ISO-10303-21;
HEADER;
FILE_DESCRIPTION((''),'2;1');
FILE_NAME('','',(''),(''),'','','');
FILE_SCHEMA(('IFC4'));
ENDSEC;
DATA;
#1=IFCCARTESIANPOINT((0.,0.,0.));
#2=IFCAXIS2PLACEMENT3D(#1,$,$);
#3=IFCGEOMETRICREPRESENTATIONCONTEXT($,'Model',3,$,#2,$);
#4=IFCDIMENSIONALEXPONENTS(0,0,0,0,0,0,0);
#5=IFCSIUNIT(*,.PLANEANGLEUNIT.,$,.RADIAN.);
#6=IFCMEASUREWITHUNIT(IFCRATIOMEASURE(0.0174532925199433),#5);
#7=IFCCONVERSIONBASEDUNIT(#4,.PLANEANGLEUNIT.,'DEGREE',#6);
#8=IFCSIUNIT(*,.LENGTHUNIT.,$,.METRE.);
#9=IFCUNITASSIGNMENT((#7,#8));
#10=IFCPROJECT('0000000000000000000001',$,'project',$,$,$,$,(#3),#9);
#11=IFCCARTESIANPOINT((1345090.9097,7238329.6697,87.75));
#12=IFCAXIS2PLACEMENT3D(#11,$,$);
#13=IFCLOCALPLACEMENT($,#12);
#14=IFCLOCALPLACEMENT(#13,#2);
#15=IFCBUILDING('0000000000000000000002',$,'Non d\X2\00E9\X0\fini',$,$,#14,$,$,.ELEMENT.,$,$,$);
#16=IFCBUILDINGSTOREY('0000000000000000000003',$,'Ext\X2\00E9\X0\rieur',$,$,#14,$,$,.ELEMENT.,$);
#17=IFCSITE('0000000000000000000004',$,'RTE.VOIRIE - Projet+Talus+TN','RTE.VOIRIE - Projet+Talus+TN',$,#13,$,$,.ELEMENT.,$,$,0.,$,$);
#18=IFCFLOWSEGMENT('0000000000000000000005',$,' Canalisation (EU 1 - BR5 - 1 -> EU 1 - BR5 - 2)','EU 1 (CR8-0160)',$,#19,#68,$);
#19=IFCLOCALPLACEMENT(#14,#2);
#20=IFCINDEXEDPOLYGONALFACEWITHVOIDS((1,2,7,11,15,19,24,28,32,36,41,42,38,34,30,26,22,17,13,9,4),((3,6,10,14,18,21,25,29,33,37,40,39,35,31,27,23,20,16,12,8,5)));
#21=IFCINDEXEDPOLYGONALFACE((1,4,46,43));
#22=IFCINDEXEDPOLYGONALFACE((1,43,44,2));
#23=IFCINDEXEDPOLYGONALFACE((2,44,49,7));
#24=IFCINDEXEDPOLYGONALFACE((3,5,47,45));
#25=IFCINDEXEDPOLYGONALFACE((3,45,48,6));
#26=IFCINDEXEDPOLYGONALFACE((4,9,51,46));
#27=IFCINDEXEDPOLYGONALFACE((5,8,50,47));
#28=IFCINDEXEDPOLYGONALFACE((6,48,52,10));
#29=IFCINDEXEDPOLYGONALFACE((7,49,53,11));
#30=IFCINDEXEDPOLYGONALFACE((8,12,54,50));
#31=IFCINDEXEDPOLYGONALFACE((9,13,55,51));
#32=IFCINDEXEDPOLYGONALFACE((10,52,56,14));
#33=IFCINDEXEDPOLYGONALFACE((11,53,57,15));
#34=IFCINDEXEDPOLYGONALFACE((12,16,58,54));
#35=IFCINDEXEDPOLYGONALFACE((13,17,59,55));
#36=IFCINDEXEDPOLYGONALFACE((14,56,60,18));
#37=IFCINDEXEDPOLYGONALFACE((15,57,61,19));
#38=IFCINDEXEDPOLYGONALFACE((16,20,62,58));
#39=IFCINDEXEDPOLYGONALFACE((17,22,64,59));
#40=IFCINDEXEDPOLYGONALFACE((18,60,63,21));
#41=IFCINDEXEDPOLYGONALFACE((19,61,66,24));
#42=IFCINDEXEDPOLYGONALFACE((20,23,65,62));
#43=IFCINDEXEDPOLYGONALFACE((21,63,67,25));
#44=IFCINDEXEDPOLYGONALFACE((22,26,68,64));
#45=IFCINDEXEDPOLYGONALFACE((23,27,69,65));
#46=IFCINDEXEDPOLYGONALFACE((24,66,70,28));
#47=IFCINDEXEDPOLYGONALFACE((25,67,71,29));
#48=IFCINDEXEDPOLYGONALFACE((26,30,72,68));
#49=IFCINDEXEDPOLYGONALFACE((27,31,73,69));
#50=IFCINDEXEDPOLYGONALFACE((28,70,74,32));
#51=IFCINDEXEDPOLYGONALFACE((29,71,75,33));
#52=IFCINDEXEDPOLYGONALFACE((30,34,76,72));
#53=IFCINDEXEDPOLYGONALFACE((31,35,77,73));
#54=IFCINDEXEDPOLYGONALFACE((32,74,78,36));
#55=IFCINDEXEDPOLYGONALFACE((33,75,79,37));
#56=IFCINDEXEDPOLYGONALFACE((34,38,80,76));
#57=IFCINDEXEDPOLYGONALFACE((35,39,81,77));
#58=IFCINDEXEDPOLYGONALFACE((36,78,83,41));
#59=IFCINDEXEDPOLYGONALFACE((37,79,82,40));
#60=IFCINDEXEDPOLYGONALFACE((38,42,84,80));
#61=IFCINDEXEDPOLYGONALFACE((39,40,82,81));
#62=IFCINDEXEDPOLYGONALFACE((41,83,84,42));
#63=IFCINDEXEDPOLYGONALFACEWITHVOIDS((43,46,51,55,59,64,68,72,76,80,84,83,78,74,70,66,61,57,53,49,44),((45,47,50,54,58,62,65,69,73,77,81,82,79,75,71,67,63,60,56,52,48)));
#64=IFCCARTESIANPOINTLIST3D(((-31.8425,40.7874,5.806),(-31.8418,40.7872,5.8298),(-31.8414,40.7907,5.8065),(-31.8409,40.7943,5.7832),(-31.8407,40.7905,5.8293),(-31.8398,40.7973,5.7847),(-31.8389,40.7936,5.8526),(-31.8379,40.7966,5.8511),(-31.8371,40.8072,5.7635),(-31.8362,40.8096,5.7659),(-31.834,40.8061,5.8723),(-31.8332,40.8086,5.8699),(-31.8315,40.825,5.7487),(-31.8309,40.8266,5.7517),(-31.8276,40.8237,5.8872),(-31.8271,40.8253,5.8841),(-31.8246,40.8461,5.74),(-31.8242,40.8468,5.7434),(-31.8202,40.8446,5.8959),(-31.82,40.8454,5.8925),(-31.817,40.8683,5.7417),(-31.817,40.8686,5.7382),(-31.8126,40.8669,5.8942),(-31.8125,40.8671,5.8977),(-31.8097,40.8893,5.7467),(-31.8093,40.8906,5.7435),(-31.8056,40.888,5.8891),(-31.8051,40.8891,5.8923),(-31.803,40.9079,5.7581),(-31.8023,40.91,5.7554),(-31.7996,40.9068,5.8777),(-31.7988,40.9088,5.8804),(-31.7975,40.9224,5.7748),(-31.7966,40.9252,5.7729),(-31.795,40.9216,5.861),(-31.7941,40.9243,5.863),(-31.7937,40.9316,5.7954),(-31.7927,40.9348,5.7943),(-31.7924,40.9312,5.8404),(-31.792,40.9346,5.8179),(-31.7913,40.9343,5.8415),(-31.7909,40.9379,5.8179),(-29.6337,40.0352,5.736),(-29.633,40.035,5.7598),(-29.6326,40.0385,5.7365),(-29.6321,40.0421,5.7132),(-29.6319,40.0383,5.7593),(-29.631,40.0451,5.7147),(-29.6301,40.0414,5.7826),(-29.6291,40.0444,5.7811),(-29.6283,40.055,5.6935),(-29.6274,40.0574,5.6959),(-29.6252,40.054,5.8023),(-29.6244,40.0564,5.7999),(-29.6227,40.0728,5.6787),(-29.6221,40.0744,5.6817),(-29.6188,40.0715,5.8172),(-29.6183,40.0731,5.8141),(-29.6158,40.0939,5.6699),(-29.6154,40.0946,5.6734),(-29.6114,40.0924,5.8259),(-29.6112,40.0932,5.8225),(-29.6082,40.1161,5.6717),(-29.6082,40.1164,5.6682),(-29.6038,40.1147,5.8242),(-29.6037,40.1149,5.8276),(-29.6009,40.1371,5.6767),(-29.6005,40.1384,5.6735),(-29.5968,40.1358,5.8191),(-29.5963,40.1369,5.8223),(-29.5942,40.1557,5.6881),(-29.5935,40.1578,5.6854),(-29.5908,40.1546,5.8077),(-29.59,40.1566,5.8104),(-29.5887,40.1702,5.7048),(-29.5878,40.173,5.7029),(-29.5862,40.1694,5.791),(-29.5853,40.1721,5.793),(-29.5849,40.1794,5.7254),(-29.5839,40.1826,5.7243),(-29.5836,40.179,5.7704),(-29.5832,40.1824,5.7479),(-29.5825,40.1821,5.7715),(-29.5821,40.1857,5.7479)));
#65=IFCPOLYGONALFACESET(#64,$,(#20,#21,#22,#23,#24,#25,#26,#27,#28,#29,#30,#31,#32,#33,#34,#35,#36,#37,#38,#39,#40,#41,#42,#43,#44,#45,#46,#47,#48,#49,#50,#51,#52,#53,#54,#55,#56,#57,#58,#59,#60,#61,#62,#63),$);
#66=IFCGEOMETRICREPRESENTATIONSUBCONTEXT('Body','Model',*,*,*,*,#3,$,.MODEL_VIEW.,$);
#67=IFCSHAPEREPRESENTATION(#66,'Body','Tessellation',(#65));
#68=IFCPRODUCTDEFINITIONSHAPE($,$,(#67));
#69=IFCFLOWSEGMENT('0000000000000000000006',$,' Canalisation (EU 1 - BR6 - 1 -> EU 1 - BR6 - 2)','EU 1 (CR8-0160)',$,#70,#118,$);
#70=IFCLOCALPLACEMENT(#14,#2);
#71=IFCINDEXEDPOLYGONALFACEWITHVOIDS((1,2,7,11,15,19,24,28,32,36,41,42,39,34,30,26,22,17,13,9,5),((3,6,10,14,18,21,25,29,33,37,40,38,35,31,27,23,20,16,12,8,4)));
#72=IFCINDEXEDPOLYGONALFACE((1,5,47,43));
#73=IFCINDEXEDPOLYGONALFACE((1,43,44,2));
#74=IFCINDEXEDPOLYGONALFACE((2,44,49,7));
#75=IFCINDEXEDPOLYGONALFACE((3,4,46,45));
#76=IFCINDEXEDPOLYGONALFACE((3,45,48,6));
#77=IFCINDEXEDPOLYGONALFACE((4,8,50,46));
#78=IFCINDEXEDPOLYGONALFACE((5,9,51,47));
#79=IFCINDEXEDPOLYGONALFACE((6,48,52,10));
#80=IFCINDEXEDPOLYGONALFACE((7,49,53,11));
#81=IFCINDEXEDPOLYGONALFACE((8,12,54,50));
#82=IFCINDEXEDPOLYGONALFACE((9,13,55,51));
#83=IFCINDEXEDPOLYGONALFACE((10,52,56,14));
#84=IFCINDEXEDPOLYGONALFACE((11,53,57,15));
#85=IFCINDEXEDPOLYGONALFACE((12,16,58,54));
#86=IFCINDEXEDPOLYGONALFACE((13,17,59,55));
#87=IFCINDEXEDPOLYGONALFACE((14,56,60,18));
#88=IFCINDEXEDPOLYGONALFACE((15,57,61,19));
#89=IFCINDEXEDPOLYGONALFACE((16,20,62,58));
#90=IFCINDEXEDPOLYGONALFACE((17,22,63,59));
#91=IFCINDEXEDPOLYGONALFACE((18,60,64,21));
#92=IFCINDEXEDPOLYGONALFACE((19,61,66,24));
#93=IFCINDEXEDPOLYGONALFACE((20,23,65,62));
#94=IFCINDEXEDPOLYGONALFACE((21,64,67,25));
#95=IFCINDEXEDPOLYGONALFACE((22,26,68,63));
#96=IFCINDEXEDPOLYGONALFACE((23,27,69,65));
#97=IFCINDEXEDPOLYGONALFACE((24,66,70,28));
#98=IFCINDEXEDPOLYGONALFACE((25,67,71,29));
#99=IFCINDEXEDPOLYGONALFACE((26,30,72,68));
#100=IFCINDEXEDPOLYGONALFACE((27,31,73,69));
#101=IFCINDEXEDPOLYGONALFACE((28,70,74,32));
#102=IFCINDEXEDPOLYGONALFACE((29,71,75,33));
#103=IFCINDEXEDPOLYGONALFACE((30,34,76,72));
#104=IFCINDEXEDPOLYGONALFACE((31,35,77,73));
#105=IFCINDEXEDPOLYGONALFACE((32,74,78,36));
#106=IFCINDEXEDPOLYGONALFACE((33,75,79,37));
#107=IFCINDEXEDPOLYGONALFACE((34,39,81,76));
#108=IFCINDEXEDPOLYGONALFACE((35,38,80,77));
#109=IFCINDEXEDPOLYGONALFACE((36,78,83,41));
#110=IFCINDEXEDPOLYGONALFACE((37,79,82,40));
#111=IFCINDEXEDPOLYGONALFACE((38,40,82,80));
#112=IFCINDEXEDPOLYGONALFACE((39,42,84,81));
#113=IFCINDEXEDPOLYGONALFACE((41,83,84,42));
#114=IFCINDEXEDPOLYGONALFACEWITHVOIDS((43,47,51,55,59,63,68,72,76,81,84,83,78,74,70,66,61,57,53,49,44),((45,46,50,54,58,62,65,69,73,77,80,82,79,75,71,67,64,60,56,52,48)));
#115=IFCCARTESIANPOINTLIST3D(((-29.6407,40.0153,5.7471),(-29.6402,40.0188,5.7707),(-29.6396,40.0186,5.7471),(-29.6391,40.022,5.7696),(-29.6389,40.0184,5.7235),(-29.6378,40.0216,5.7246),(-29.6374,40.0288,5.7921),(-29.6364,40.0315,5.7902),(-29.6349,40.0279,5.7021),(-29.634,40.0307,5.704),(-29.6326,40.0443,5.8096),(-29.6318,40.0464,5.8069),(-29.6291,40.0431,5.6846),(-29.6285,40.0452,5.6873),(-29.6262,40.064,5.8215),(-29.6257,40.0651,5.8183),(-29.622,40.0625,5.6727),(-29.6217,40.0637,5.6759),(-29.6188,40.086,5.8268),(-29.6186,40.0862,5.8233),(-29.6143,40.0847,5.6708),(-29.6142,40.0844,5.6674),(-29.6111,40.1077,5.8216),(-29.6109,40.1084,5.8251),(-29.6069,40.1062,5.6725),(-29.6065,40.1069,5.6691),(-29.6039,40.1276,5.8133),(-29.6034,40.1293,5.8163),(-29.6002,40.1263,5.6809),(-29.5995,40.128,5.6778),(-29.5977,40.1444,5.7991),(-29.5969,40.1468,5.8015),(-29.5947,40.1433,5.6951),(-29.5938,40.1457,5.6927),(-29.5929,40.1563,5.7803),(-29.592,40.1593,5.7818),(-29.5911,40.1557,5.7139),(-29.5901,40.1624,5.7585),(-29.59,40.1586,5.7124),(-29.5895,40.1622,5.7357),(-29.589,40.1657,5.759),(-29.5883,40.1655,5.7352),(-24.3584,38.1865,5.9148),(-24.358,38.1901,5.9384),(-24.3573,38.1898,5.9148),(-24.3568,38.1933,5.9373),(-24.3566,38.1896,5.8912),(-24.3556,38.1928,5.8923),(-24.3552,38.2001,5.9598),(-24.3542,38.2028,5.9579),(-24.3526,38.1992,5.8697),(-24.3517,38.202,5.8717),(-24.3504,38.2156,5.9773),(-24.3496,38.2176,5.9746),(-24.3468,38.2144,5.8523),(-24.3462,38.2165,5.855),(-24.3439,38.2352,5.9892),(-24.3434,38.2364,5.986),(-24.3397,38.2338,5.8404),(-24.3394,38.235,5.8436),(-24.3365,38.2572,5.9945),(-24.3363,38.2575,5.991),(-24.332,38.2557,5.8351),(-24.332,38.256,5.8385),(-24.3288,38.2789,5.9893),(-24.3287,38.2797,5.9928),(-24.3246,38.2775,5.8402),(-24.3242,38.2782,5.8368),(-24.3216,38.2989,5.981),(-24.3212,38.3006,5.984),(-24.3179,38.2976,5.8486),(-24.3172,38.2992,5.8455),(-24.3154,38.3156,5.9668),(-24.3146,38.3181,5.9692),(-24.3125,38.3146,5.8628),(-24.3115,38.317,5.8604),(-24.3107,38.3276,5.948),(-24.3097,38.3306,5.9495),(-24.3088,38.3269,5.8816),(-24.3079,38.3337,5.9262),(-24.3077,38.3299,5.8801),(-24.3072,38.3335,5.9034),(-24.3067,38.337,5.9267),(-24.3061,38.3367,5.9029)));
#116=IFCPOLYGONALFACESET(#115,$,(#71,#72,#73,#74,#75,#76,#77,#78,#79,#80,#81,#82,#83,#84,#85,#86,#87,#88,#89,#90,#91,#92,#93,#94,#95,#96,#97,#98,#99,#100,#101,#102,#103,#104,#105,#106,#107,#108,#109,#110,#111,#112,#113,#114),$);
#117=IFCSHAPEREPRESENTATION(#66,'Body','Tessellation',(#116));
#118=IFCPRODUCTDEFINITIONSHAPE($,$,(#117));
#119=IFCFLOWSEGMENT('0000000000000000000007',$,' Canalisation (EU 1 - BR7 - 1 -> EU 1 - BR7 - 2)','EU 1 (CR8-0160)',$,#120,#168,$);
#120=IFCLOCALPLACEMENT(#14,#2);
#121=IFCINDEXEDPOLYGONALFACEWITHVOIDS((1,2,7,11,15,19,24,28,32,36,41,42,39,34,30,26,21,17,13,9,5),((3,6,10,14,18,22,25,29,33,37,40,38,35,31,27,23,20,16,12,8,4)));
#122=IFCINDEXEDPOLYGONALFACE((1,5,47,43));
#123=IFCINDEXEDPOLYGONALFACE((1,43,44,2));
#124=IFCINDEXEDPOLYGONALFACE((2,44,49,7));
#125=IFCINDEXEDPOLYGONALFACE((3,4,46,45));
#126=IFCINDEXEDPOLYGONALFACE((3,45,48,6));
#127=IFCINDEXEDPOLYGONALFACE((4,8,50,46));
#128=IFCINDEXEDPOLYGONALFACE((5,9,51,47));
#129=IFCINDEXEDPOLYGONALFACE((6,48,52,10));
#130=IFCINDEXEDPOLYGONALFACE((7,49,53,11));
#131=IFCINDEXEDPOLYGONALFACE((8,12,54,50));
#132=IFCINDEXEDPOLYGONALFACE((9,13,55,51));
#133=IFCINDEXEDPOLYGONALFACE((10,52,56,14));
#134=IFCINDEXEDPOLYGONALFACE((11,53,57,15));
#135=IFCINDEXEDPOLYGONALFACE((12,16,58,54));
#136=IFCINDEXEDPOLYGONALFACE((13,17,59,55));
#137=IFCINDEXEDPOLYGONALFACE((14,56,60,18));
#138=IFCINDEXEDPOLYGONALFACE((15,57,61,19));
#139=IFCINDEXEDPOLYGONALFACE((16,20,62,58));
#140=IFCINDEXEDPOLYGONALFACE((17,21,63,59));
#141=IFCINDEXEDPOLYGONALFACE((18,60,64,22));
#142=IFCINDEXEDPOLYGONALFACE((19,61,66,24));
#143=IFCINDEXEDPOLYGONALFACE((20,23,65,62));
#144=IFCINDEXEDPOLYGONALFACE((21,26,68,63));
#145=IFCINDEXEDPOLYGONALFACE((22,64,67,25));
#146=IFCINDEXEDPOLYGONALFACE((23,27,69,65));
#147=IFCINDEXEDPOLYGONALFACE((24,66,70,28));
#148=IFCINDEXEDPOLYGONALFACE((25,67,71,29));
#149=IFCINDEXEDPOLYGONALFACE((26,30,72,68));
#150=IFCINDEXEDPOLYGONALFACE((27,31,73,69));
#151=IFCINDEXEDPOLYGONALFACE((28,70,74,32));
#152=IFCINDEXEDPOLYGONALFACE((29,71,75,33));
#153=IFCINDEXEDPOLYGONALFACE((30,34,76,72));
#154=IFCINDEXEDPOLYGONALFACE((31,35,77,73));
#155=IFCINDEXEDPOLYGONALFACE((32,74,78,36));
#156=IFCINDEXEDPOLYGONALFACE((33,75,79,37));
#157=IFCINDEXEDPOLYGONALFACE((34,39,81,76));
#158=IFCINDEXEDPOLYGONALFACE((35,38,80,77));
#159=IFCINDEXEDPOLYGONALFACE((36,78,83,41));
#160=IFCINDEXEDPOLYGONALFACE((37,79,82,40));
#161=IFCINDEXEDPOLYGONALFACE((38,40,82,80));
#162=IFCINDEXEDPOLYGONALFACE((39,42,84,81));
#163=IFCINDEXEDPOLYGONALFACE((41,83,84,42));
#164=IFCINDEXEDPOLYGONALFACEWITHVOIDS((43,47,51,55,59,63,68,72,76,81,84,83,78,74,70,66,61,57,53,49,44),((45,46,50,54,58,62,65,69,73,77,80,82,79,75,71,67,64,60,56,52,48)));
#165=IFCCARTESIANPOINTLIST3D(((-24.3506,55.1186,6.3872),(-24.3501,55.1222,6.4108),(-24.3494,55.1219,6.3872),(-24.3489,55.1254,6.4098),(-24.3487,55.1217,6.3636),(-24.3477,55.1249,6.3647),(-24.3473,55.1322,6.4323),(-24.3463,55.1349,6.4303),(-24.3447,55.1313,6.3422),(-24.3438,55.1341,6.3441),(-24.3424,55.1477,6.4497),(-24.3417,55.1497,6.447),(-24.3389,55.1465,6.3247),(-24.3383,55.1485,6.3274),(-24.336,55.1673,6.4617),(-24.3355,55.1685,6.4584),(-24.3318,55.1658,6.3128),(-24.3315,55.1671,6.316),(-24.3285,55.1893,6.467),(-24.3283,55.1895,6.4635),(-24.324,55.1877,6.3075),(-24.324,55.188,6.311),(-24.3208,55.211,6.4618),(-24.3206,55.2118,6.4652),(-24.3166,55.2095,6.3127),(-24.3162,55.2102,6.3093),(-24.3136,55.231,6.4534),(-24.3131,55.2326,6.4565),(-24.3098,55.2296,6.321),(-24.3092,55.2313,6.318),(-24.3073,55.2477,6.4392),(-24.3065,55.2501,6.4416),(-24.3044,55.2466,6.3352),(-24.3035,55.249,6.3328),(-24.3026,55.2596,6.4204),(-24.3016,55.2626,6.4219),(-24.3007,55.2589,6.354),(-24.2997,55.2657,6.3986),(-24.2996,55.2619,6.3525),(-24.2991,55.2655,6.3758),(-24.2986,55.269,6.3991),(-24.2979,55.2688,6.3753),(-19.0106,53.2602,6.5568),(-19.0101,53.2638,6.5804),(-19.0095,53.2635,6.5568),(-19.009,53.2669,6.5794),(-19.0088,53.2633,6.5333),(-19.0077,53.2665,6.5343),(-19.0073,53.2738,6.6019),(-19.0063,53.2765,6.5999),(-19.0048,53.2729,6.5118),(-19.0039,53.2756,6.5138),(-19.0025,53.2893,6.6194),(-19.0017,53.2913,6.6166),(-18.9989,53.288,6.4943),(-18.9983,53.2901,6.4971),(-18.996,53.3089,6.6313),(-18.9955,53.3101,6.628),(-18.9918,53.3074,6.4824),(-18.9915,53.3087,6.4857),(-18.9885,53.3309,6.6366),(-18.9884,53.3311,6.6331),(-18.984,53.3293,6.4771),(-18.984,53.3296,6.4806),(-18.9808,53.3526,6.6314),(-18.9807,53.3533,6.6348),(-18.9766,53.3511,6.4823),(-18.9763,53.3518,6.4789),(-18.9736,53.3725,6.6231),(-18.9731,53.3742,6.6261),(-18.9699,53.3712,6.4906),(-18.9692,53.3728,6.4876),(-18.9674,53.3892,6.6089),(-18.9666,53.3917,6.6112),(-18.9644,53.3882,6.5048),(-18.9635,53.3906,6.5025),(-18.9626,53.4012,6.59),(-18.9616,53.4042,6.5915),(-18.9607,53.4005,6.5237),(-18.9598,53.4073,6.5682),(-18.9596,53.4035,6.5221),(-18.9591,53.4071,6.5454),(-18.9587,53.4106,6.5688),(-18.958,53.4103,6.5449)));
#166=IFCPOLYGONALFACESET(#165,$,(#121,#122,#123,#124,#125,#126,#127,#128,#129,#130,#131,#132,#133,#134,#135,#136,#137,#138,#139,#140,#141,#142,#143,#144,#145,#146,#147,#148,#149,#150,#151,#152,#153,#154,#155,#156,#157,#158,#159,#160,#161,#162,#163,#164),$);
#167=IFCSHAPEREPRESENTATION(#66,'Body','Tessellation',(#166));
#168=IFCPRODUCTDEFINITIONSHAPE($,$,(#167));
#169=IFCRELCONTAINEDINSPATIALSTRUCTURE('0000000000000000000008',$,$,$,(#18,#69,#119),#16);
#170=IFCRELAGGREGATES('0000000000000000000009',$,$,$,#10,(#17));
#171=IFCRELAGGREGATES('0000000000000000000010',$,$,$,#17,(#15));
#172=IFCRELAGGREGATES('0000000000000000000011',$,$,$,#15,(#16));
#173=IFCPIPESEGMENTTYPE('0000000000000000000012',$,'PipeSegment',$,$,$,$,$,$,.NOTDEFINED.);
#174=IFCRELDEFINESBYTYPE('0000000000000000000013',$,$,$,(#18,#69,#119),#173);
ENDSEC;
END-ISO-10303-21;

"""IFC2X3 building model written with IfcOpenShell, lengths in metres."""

from ifc_helpers import new_model, entity, si_unit, converted_unit, frame, origin, origin_2d_with_axis, place, context, subcontext, project, spatial, hollow_circle, extrude, type_object, element, save


model = new_model("IFC2X3")

# Units and contexts
model_context = context("Model", 3, world=origin())
body_context = subcontext(model_context, "Body", "Model", "MODEL_VIEW")
ifc_project = project(units=[converted_unit("PLANEANGLEUNIT", "DEGREE", entity("IfcRatioMeasure", 0.0174532925199433), si_unit("PLANEANGLEUNIT", "RADIAN"), dimensions=[0, 0, 0, 0, 0, 0, 0]), si_unit("LENGTHUNIT", "METRE")], contexts=[model_context])

# Site, building, storey
site_placement = place(None, frame((1345090.9097, 7238329.6697, 87.75)))
site = spatial("IfcSite", under=ifc_project, at=site_placement, Name="RTE.VOIRIE - Projet+Talus+TN", Description="RTE.VOIRIE - Projet+Talus+TN", CompositionType="ELEMENT", RefElevation=0.0)
placement = place(site_placement, origin())
building = spatial("IfcBuilding", under=site, at=placement, Name="Non défini", CompositionType="ELEMENT")
storey = spatial("IfcBuildingStorey", under=building, at=placement, Name="Extérieur", CompositionType="ELEMENT")

# Flow segments
pipe_segment_type_1 = type_object("IfcPipeSegmentType", Name="PipeSegment", PredefinedType="NOTDEFINED")
flow_segment_1_placement = place(placement, origin())
element("IfcFlowSegment", 1, at=flow_segment_1_placement, inside=storey, type_object=pipe_segment_type_1, Name=" Canalisation (EU 1 - BR5 - 1 -> EU 1 - BR5 - 2)", Description="EU 1 (CR8-0160)", context=body_context, shape_type="SweptSolid", body=[
    extrude(hollow_circle(Radius=0.08, WallThickness=0.0035, at=origin_2d_with_axis()), frame((-31.8166, 40.8622, 5.8179), z_axis=(0.94619, -0.322219, -0.029987), x_axis=(0.322219, 0.94619, 0.0)), (0.0, 0.0, 1.0), 2.3344),
])
flow_segment_2_placement = place(placement, origin())
element("IfcFlowSegment", 2, at=flow_segment_2_placement, inside=storey, type_object=pipe_segment_type_1, Name=" Canalisation (EU 1 - BR6 - 1 -> EU 1 - BR6 - 2)", Description="EU 1 (CR8-0160)", context=body_context, shape_type="SweptSolid", body=[
    extrude(hollow_circle(Radius=0.08, WallThickness=0.0035, at=origin_2d_with_axis()), frame((-24.3323, 38.2621, 5.9148), z_axis=(-0.944547, 0.327006, -0.029987), x_axis=(-0.327006, -0.944547, 0.0)), (0.0, 0.0, 1.0), 5.5924),
])
flow_segment_3_placement = place(placement, origin())
element("IfcFlowSegment", 3, at=flow_segment_3_placement, inside=storey, type_object=pipe_segment_type_1, Name=" Canalisation (EU 1 - BR7 - 1 -> EU 1 - BR7 - 2)", Description="EU 1 (CR8-0160)", context=body_context, shape_type="SweptSolid", body=[
    extrude(hollow_circle(Radius=0.08, WallThickness=0.0035, at=origin_2d_with_axis()), frame((-18.9843, 53.3358, 6.5568), z_axis=(-0.944015, 0.328538, -0.029987), x_axis=(-0.328538, -0.944015, 0.0)), (0.0, 0.0, 1.0), 5.6566),
])

save(model, "model.ifc")
